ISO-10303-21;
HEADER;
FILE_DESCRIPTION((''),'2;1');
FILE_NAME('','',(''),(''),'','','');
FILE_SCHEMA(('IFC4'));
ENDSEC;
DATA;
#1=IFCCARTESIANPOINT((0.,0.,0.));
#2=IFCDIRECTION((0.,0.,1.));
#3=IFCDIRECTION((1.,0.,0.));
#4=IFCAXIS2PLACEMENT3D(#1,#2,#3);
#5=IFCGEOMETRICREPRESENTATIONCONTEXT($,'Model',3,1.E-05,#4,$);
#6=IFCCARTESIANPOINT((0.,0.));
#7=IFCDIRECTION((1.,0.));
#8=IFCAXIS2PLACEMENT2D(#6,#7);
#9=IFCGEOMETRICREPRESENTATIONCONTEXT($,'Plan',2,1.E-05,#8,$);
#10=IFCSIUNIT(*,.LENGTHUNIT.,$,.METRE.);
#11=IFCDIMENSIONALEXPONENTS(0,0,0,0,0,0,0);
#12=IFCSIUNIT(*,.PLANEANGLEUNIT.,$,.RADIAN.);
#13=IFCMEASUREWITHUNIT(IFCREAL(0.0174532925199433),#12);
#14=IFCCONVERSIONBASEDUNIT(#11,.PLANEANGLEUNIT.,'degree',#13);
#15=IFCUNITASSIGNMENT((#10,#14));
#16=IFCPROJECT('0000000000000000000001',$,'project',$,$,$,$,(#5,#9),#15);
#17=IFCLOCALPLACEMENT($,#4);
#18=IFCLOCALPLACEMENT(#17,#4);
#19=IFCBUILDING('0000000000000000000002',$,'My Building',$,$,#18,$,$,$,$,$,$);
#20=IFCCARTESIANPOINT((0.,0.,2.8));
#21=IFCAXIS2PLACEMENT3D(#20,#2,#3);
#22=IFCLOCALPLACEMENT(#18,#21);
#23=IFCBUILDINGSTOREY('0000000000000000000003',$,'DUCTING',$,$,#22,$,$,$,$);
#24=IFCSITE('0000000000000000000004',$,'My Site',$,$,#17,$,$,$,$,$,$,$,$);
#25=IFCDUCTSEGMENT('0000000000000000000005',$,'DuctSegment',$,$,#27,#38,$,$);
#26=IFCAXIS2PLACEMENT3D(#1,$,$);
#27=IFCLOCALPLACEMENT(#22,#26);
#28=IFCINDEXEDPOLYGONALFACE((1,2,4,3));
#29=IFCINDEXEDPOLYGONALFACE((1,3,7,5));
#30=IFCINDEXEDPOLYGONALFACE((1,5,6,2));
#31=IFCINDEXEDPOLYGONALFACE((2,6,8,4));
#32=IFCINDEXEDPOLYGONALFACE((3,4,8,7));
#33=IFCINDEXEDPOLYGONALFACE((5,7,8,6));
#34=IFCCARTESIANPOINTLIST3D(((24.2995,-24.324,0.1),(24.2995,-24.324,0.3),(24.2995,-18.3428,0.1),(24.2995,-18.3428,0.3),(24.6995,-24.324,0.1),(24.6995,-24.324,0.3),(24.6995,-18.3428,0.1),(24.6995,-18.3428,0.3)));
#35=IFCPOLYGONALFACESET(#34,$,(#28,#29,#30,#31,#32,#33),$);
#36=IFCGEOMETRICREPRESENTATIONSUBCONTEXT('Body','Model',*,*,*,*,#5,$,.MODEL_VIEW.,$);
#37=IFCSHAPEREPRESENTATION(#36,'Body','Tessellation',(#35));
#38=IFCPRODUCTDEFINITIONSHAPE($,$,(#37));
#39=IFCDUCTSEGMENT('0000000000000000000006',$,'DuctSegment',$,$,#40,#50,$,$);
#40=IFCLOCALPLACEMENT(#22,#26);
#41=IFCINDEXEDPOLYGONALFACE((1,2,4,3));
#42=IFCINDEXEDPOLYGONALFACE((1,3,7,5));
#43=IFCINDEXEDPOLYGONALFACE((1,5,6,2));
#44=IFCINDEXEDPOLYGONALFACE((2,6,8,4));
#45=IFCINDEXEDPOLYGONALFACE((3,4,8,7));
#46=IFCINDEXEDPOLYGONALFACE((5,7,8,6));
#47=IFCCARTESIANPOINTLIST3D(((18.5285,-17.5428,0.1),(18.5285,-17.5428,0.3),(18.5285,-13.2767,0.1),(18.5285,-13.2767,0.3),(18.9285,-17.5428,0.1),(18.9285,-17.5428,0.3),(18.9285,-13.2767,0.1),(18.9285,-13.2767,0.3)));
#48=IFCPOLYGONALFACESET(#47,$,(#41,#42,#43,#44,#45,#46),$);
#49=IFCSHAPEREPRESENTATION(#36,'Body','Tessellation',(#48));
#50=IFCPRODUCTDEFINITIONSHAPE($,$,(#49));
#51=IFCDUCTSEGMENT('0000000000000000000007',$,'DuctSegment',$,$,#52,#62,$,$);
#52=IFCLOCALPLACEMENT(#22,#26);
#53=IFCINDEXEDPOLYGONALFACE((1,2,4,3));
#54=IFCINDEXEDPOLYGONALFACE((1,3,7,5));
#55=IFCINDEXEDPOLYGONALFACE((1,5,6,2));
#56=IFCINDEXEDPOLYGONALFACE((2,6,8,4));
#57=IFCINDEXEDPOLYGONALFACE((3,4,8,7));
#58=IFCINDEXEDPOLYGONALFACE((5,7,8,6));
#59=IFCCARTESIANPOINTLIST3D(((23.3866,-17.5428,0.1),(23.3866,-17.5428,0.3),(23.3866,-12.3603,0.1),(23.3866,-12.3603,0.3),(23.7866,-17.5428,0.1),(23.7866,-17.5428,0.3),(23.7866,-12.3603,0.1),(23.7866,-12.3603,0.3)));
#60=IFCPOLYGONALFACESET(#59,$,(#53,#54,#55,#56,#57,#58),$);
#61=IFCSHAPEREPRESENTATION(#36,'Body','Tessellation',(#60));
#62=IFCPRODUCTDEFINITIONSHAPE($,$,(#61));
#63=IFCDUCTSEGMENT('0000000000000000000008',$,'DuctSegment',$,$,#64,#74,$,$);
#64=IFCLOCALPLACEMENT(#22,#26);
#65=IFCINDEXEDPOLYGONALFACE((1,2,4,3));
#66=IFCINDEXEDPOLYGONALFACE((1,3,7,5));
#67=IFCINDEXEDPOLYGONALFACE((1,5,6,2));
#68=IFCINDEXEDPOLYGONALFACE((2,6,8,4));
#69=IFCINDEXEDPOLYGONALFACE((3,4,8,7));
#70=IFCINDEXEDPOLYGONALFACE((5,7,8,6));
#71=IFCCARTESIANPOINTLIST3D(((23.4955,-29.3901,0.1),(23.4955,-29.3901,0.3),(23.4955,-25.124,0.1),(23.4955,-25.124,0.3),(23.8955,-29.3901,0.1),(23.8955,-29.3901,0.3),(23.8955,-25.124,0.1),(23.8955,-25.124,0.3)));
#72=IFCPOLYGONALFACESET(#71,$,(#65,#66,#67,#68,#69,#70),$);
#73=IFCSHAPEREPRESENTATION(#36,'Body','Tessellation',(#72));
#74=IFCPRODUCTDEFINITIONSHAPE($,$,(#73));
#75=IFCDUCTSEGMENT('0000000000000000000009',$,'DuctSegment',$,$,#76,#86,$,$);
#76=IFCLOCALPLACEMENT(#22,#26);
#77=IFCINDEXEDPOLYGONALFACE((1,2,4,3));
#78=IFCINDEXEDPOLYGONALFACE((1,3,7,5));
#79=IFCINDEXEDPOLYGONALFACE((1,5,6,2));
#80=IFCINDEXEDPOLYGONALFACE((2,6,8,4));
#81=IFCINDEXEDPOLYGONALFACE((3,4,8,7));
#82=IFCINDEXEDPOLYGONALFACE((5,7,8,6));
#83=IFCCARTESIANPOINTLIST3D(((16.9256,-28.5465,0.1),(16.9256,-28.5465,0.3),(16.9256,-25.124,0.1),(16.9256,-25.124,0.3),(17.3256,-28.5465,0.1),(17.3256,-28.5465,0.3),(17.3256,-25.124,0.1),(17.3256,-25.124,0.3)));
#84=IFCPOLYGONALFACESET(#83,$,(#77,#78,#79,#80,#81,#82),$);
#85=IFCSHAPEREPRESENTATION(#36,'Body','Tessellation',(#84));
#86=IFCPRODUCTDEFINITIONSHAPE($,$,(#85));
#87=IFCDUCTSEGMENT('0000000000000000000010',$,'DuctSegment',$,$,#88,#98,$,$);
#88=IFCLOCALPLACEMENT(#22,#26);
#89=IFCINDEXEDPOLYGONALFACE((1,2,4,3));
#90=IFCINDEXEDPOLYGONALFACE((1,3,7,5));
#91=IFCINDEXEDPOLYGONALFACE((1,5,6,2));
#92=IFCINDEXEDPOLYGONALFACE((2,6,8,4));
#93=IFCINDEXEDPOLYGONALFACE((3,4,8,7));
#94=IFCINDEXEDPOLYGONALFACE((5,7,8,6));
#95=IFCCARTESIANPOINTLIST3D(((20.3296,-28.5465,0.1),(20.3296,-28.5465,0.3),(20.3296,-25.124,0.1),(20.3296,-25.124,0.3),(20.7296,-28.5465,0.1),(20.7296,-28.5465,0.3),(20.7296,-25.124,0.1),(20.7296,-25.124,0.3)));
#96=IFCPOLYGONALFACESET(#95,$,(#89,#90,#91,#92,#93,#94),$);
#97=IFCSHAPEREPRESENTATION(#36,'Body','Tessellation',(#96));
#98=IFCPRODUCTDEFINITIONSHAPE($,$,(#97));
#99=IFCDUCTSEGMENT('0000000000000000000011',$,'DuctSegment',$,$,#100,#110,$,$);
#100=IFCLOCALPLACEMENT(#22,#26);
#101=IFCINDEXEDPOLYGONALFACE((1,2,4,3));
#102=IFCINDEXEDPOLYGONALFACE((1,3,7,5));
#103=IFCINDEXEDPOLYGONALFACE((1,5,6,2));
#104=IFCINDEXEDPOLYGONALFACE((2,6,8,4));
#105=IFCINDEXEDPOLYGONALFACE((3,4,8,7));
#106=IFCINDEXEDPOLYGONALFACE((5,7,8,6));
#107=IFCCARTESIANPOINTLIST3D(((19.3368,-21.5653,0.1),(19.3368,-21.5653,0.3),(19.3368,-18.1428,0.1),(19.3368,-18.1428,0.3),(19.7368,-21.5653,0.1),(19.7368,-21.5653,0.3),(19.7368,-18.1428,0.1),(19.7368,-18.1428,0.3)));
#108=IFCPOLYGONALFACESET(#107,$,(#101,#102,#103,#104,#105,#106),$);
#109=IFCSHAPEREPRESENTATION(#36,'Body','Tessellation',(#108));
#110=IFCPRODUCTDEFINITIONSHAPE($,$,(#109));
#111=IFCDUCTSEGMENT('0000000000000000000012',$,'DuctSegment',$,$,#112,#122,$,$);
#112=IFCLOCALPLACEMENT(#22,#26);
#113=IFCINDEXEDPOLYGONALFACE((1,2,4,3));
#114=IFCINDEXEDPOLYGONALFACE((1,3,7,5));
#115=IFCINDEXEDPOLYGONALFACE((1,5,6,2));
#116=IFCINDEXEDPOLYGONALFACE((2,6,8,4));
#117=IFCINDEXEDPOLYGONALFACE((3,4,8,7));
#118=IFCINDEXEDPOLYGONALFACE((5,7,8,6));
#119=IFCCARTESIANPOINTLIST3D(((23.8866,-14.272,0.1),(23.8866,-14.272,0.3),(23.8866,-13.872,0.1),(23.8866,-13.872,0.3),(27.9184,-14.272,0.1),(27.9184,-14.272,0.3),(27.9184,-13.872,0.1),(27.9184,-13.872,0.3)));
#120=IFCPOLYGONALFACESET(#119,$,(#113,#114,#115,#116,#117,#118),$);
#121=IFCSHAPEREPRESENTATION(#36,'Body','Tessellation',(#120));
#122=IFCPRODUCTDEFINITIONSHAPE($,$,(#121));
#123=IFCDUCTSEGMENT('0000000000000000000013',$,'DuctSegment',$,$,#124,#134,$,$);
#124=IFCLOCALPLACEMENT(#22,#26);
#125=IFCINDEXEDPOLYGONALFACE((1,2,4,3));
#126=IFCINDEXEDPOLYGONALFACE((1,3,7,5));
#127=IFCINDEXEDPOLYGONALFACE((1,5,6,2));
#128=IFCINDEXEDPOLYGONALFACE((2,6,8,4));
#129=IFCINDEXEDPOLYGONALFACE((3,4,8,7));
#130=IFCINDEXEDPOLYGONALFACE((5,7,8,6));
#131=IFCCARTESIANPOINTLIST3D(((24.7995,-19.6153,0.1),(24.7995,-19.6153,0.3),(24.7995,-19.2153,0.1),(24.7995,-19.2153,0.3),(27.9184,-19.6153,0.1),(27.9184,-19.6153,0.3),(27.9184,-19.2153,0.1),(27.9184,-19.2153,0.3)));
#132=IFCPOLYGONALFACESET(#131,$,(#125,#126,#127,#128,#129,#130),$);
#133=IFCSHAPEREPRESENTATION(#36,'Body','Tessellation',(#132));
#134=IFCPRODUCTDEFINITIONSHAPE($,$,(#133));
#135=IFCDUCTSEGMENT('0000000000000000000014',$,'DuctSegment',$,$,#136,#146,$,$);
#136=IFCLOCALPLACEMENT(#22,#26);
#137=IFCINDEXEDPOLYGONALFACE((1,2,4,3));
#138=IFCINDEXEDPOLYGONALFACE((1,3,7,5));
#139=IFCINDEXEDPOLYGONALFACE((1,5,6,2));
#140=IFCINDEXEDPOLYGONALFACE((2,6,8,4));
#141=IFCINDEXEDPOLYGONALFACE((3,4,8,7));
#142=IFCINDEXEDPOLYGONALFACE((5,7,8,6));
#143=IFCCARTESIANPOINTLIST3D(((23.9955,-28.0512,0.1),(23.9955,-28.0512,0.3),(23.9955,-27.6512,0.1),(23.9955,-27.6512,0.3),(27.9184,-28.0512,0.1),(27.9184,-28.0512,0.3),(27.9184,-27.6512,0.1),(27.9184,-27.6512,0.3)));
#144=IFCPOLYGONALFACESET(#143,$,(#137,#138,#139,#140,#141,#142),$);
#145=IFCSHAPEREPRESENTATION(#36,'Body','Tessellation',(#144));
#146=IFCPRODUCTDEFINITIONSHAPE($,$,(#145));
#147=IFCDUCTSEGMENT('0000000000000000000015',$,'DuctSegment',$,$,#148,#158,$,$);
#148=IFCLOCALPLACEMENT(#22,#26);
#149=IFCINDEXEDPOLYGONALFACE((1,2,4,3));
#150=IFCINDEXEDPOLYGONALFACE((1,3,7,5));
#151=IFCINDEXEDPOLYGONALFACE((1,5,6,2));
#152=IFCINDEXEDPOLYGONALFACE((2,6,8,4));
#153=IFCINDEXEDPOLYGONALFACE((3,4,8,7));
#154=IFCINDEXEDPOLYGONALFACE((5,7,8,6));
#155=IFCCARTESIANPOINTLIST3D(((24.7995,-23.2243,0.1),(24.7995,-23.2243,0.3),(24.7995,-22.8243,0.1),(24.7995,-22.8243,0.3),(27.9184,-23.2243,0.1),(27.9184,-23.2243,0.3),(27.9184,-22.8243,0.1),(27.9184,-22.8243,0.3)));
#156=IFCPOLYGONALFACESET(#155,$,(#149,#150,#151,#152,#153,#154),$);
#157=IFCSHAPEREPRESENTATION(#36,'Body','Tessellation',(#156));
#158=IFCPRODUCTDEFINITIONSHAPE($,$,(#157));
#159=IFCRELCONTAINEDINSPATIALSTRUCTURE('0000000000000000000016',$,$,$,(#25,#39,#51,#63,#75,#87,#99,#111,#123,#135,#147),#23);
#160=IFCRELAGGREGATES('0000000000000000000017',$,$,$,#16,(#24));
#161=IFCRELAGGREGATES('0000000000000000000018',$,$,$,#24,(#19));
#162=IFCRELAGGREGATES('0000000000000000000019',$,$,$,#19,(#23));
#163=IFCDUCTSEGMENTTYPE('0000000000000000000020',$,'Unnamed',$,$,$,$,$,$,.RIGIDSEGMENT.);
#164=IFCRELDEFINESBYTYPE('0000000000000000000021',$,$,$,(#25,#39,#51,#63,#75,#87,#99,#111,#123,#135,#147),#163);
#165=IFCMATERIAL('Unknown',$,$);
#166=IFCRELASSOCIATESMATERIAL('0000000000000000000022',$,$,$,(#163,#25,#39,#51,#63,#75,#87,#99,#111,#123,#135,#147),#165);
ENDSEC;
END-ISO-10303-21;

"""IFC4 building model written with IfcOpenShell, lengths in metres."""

from ifc_helpers import new_model, entity, si_unit, converted_unit, frame, origin_with_axes, origin_2d_with_axis, place, context, subcontext, project, spatial, rectangle, extrude, material, material_profile, profile_set, profile_usage, type_object, element, save


model = new_model("IFC4")

# Units and contexts
model_context = context("Model", 3, precision=1e-05, world=origin_with_axes())
plan_context = context("Plan", 2, precision=1e-05, world=origin_2d_with_axis())
body_context = subcontext(model_context, "Body", "Model", "MODEL_VIEW")
ifc_project = project(units=[si_unit("LENGTHUNIT", "METRE"), converted_unit("PLANEANGLEUNIT", "degree", entity("IfcReal", 0.0174532925199433), si_unit("PLANEANGLEUNIT", "RADIAN"), dimensions=[0, 0, 0, 0, 0, 0, 0])], contexts=[model_context, plan_context])

# Site, building, storey
site_placement = place(None, origin_with_axes())
site = spatial("IfcSite", under=ifc_project, at=site_placement, Name="My Site")
building_placement = place(site_placement, origin_with_axes())
building = spatial("IfcBuilding", under=site, at=building_placement, Name="My Building")
storey_placement = place(building_placement, frame((0.0, 0.0, 2.8), z_axis=(0.0, 0.0, 1.0), x_axis=(1.0, 0.0, 0.0)))
storey = spatial("IfcBuildingStorey", under=building, at=storey_placement, Name="DUCTING")

# Duct segments
ifc_material = material(Name="Unknown")
ifc_material_profile_1 = material_profile(ifc_material, rectangle(XDim=0.4, YDim=0.2))
ifc_profile_set_1 = profile_set([ifc_material_profile_1])
ifc_profile_usage_1 = profile_usage(ifc_profile_set_1, cardinal=5)
duct_segment_type = type_object("IfcDuctSegmentType", Name="Unnamed", PredefinedType="RIGIDSEGMENT", material=ifc_profile_set_1)
duct_segment_1_placement = place(storey_placement, frame((24.4995, -18.3428, 0.2), z_axis=(0.0, -1.0, 0.0), x_axis=(1.0, 0.0, 0.0)))
element("IfcDuctSegment", 1, at=duct_segment_1_placement, inside=storey, type_object=duct_segment_type, material=ifc_profile_usage_1, Name="DuctSegment", context=body_context, shape_type="SweptSolid", body=[
    extrude(rectangle(XDim=0.4, YDim=0.2), origin_with_axes(), (0.0, 0.0, 1.0), 5.9812),
])
ifc_profile_usage_2 = profile_usage(ifc_profile_set_1, cardinal=5)
duct_segment_2_placement = place(storey_placement, frame((18.7285, -17.5428, 0.2), z_axis=(0.0, 1.0, 0.0), x_axis=(-1.0, 0.0, 0.0)))
element("IfcDuctSegment", 2, at=duct_segment_2_placement, inside=storey, type_object=duct_segment_type, material=ifc_profile_usage_2, Name="DuctSegment", context=body_context, shape_type="SweptSolid", body=[
    extrude(rectangle(XDim=0.4, YDim=0.2), origin_with_axes(), (0.0, 0.0, 1.0), 4.2661),
])
ifc_profile_usage_3 = profile_usage(ifc_profile_set_1, cardinal=5)
duct_segment_3_placement = place(storey_placement, frame((23.5866, -17.5428, 0.2), z_axis=(0.0, 1.0, 0.0), x_axis=(-1.0, 0.0, 0.0)))
element("IfcDuctSegment", 3, at=duct_segment_3_placement, inside=storey, type_object=duct_segment_type, material=ifc_profile_usage_3, Name="DuctSegment", context=body_context, shape_type="SweptSolid", body=[
    extrude(rectangle(XDim=0.4, YDim=0.2), origin_with_axes(), (0.0, 0.0, 1.0), 5.1825),
])
ifc_profile_usage_4 = profile_usage(ifc_profile_set_1, cardinal=5)
duct_segment_4_placement = place(storey_placement, frame((23.6955, -25.124, 0.2), z_axis=(0.0, -1.0, 0.0), x_axis=(1.0, 0.0, 0.0)))
element("IfcDuctSegment", 4, at=duct_segment_4_placement, inside=storey, type_object=duct_segment_type, material=ifc_profile_usage_4, Name="DuctSegment", context=body_context, shape_type="SweptSolid", body=[
    extrude(rectangle(XDim=0.4, YDim=0.2), origin_with_axes(), (0.0, 0.0, 1.0), 4.2661),
])
ifc_profile_usage_5 = profile_usage(ifc_profile_set_1, cardinal=5)
duct_segment_5_placement = place(storey_placement, frame((17.1256, -25.124, 0.2), z_axis=(0.0, -1.0, 0.0), x_axis=(1.0, 0.0, 0.0)))
element("IfcDuctSegment", 5, at=duct_segment_5_placement, inside=storey, type_object=duct_segment_type, material=ifc_profile_usage_5, Name="DuctSegment", context=body_context, shape_type="SweptSolid", body=[
    extrude(rectangle(XDim=0.4, YDim=0.2), origin_with_axes(), (0.0, 0.0, 1.0), 3.4225),
])
ifc_profile_usage_6 = profile_usage(ifc_profile_set_1, cardinal=5)
duct_segment_6_placement = place(storey_placement, frame((20.5296, -25.124, 0.2), z_axis=(0.0, -1.0, 0.0), x_axis=(1.0, 0.0, 0.0)))
element("IfcDuctSegment", 6, at=duct_segment_6_placement, inside=storey, type_object=duct_segment_type, material=ifc_profile_usage_6, Name="DuctSegment", context=body_context, shape_type="SweptSolid", body=[
    extrude(rectangle(XDim=0.4, YDim=0.2), origin_with_axes(), (0.0, 0.0, 1.0), 3.4225),
])
ifc_profile_usage_7 = profile_usage(ifc_profile_set_1, cardinal=5)
duct_segment_7_placement = place(storey_placement, frame((19.5368, -18.1428, 0.2), z_axis=(0.0, -1.0, 0.0), x_axis=(1.0, 0.0, 0.0)))
element("IfcDuctSegment", 7, at=duct_segment_7_placement, inside=storey, type_object=duct_segment_type, material=ifc_profile_usage_7, Name="DuctSegment", context=body_context, shape_type="SweptSolid", body=[
    extrude(rectangle(XDim=0.4, YDim=0.2), origin_with_axes(), (0.0, 0.0, 1.0), 3.4225),
])
ifc_profile_usage_8 = profile_usage(ifc_profile_set_1, cardinal=5)
duct_segment_8_placement = place(storey_placement, frame((23.8866, -14.072, 0.2), z_axis=(1.0, 0.0, 0.0), x_axis=(0.0, 1.0, 0.0)))
element("IfcDuctSegment", 8, at=duct_segment_8_placement, inside=storey, type_object=duct_segment_type, material=ifc_profile_usage_8, Name="DuctSegment", context=body_context, shape_type="SweptSolid", body=[
    extrude(rectangle(XDim=0.4, YDim=0.2), origin_with_axes(), (0.0, 0.0, 1.0), 4.0318),
])
ifc_profile_usage_9 = profile_usage(ifc_profile_set_1, cardinal=5)
duct_segment_9_placement = place(storey_placement, frame((24.7995, -19.4153, 0.2), z_axis=(1.0, 0.0, 0.0), x_axis=(0.0, 1.0, 0.0)))
element("IfcDuctSegment", 9, at=duct_segment_9_placement, inside=storey, type_object=duct_segment_type, material=ifc_profile_usage_9, Name="DuctSegment", context=body_context, shape_type="SweptSolid", body=[
    extrude(rectangle(XDim=0.4, YDim=0.2), origin_with_axes(), (0.0, 0.0, 1.0), 3.1188),
])
ifc_profile_usage_10 = profile_usage(ifc_profile_set_1, cardinal=5)
duct_segment_10_placement = place(storey_placement, frame((23.9955, -27.8512, 0.2), z_axis=(1.0, 0.0, 0.0), x_axis=(0.0, 1.0, 0.0)))
element("IfcDuctSegment", 10, at=duct_segment_10_placement, inside=storey, type_object=duct_segment_type, material=ifc_profile_usage_10, Name="DuctSegment", context=body_context, shape_type="SweptSolid", body=[
    extrude(rectangle(XDim=0.4, YDim=0.2), origin_with_axes(), (0.0, 0.0, 1.0), 3.9229),
])
ifc_profile_usage_11 = profile_usage(ifc_profile_set_1, cardinal=5)
duct_segment_11_placement = place(storey_placement, frame((24.7995, -23.0243, 0.2), z_axis=(1.0, 0.0, 0.0), x_axis=(0.0, 1.0, 0.0)))
element("IfcDuctSegment", 11, at=duct_segment_11_placement, inside=storey, type_object=duct_segment_type, material=ifc_profile_usage_11, Name="DuctSegment", context=body_context, shape_type="SweptSolid", body=[
    extrude(rectangle(XDim=0.4, YDim=0.2), origin_with_axes(), (0.0, 0.0, 1.0), 3.1188),
])

save(model, "model.ifc")
